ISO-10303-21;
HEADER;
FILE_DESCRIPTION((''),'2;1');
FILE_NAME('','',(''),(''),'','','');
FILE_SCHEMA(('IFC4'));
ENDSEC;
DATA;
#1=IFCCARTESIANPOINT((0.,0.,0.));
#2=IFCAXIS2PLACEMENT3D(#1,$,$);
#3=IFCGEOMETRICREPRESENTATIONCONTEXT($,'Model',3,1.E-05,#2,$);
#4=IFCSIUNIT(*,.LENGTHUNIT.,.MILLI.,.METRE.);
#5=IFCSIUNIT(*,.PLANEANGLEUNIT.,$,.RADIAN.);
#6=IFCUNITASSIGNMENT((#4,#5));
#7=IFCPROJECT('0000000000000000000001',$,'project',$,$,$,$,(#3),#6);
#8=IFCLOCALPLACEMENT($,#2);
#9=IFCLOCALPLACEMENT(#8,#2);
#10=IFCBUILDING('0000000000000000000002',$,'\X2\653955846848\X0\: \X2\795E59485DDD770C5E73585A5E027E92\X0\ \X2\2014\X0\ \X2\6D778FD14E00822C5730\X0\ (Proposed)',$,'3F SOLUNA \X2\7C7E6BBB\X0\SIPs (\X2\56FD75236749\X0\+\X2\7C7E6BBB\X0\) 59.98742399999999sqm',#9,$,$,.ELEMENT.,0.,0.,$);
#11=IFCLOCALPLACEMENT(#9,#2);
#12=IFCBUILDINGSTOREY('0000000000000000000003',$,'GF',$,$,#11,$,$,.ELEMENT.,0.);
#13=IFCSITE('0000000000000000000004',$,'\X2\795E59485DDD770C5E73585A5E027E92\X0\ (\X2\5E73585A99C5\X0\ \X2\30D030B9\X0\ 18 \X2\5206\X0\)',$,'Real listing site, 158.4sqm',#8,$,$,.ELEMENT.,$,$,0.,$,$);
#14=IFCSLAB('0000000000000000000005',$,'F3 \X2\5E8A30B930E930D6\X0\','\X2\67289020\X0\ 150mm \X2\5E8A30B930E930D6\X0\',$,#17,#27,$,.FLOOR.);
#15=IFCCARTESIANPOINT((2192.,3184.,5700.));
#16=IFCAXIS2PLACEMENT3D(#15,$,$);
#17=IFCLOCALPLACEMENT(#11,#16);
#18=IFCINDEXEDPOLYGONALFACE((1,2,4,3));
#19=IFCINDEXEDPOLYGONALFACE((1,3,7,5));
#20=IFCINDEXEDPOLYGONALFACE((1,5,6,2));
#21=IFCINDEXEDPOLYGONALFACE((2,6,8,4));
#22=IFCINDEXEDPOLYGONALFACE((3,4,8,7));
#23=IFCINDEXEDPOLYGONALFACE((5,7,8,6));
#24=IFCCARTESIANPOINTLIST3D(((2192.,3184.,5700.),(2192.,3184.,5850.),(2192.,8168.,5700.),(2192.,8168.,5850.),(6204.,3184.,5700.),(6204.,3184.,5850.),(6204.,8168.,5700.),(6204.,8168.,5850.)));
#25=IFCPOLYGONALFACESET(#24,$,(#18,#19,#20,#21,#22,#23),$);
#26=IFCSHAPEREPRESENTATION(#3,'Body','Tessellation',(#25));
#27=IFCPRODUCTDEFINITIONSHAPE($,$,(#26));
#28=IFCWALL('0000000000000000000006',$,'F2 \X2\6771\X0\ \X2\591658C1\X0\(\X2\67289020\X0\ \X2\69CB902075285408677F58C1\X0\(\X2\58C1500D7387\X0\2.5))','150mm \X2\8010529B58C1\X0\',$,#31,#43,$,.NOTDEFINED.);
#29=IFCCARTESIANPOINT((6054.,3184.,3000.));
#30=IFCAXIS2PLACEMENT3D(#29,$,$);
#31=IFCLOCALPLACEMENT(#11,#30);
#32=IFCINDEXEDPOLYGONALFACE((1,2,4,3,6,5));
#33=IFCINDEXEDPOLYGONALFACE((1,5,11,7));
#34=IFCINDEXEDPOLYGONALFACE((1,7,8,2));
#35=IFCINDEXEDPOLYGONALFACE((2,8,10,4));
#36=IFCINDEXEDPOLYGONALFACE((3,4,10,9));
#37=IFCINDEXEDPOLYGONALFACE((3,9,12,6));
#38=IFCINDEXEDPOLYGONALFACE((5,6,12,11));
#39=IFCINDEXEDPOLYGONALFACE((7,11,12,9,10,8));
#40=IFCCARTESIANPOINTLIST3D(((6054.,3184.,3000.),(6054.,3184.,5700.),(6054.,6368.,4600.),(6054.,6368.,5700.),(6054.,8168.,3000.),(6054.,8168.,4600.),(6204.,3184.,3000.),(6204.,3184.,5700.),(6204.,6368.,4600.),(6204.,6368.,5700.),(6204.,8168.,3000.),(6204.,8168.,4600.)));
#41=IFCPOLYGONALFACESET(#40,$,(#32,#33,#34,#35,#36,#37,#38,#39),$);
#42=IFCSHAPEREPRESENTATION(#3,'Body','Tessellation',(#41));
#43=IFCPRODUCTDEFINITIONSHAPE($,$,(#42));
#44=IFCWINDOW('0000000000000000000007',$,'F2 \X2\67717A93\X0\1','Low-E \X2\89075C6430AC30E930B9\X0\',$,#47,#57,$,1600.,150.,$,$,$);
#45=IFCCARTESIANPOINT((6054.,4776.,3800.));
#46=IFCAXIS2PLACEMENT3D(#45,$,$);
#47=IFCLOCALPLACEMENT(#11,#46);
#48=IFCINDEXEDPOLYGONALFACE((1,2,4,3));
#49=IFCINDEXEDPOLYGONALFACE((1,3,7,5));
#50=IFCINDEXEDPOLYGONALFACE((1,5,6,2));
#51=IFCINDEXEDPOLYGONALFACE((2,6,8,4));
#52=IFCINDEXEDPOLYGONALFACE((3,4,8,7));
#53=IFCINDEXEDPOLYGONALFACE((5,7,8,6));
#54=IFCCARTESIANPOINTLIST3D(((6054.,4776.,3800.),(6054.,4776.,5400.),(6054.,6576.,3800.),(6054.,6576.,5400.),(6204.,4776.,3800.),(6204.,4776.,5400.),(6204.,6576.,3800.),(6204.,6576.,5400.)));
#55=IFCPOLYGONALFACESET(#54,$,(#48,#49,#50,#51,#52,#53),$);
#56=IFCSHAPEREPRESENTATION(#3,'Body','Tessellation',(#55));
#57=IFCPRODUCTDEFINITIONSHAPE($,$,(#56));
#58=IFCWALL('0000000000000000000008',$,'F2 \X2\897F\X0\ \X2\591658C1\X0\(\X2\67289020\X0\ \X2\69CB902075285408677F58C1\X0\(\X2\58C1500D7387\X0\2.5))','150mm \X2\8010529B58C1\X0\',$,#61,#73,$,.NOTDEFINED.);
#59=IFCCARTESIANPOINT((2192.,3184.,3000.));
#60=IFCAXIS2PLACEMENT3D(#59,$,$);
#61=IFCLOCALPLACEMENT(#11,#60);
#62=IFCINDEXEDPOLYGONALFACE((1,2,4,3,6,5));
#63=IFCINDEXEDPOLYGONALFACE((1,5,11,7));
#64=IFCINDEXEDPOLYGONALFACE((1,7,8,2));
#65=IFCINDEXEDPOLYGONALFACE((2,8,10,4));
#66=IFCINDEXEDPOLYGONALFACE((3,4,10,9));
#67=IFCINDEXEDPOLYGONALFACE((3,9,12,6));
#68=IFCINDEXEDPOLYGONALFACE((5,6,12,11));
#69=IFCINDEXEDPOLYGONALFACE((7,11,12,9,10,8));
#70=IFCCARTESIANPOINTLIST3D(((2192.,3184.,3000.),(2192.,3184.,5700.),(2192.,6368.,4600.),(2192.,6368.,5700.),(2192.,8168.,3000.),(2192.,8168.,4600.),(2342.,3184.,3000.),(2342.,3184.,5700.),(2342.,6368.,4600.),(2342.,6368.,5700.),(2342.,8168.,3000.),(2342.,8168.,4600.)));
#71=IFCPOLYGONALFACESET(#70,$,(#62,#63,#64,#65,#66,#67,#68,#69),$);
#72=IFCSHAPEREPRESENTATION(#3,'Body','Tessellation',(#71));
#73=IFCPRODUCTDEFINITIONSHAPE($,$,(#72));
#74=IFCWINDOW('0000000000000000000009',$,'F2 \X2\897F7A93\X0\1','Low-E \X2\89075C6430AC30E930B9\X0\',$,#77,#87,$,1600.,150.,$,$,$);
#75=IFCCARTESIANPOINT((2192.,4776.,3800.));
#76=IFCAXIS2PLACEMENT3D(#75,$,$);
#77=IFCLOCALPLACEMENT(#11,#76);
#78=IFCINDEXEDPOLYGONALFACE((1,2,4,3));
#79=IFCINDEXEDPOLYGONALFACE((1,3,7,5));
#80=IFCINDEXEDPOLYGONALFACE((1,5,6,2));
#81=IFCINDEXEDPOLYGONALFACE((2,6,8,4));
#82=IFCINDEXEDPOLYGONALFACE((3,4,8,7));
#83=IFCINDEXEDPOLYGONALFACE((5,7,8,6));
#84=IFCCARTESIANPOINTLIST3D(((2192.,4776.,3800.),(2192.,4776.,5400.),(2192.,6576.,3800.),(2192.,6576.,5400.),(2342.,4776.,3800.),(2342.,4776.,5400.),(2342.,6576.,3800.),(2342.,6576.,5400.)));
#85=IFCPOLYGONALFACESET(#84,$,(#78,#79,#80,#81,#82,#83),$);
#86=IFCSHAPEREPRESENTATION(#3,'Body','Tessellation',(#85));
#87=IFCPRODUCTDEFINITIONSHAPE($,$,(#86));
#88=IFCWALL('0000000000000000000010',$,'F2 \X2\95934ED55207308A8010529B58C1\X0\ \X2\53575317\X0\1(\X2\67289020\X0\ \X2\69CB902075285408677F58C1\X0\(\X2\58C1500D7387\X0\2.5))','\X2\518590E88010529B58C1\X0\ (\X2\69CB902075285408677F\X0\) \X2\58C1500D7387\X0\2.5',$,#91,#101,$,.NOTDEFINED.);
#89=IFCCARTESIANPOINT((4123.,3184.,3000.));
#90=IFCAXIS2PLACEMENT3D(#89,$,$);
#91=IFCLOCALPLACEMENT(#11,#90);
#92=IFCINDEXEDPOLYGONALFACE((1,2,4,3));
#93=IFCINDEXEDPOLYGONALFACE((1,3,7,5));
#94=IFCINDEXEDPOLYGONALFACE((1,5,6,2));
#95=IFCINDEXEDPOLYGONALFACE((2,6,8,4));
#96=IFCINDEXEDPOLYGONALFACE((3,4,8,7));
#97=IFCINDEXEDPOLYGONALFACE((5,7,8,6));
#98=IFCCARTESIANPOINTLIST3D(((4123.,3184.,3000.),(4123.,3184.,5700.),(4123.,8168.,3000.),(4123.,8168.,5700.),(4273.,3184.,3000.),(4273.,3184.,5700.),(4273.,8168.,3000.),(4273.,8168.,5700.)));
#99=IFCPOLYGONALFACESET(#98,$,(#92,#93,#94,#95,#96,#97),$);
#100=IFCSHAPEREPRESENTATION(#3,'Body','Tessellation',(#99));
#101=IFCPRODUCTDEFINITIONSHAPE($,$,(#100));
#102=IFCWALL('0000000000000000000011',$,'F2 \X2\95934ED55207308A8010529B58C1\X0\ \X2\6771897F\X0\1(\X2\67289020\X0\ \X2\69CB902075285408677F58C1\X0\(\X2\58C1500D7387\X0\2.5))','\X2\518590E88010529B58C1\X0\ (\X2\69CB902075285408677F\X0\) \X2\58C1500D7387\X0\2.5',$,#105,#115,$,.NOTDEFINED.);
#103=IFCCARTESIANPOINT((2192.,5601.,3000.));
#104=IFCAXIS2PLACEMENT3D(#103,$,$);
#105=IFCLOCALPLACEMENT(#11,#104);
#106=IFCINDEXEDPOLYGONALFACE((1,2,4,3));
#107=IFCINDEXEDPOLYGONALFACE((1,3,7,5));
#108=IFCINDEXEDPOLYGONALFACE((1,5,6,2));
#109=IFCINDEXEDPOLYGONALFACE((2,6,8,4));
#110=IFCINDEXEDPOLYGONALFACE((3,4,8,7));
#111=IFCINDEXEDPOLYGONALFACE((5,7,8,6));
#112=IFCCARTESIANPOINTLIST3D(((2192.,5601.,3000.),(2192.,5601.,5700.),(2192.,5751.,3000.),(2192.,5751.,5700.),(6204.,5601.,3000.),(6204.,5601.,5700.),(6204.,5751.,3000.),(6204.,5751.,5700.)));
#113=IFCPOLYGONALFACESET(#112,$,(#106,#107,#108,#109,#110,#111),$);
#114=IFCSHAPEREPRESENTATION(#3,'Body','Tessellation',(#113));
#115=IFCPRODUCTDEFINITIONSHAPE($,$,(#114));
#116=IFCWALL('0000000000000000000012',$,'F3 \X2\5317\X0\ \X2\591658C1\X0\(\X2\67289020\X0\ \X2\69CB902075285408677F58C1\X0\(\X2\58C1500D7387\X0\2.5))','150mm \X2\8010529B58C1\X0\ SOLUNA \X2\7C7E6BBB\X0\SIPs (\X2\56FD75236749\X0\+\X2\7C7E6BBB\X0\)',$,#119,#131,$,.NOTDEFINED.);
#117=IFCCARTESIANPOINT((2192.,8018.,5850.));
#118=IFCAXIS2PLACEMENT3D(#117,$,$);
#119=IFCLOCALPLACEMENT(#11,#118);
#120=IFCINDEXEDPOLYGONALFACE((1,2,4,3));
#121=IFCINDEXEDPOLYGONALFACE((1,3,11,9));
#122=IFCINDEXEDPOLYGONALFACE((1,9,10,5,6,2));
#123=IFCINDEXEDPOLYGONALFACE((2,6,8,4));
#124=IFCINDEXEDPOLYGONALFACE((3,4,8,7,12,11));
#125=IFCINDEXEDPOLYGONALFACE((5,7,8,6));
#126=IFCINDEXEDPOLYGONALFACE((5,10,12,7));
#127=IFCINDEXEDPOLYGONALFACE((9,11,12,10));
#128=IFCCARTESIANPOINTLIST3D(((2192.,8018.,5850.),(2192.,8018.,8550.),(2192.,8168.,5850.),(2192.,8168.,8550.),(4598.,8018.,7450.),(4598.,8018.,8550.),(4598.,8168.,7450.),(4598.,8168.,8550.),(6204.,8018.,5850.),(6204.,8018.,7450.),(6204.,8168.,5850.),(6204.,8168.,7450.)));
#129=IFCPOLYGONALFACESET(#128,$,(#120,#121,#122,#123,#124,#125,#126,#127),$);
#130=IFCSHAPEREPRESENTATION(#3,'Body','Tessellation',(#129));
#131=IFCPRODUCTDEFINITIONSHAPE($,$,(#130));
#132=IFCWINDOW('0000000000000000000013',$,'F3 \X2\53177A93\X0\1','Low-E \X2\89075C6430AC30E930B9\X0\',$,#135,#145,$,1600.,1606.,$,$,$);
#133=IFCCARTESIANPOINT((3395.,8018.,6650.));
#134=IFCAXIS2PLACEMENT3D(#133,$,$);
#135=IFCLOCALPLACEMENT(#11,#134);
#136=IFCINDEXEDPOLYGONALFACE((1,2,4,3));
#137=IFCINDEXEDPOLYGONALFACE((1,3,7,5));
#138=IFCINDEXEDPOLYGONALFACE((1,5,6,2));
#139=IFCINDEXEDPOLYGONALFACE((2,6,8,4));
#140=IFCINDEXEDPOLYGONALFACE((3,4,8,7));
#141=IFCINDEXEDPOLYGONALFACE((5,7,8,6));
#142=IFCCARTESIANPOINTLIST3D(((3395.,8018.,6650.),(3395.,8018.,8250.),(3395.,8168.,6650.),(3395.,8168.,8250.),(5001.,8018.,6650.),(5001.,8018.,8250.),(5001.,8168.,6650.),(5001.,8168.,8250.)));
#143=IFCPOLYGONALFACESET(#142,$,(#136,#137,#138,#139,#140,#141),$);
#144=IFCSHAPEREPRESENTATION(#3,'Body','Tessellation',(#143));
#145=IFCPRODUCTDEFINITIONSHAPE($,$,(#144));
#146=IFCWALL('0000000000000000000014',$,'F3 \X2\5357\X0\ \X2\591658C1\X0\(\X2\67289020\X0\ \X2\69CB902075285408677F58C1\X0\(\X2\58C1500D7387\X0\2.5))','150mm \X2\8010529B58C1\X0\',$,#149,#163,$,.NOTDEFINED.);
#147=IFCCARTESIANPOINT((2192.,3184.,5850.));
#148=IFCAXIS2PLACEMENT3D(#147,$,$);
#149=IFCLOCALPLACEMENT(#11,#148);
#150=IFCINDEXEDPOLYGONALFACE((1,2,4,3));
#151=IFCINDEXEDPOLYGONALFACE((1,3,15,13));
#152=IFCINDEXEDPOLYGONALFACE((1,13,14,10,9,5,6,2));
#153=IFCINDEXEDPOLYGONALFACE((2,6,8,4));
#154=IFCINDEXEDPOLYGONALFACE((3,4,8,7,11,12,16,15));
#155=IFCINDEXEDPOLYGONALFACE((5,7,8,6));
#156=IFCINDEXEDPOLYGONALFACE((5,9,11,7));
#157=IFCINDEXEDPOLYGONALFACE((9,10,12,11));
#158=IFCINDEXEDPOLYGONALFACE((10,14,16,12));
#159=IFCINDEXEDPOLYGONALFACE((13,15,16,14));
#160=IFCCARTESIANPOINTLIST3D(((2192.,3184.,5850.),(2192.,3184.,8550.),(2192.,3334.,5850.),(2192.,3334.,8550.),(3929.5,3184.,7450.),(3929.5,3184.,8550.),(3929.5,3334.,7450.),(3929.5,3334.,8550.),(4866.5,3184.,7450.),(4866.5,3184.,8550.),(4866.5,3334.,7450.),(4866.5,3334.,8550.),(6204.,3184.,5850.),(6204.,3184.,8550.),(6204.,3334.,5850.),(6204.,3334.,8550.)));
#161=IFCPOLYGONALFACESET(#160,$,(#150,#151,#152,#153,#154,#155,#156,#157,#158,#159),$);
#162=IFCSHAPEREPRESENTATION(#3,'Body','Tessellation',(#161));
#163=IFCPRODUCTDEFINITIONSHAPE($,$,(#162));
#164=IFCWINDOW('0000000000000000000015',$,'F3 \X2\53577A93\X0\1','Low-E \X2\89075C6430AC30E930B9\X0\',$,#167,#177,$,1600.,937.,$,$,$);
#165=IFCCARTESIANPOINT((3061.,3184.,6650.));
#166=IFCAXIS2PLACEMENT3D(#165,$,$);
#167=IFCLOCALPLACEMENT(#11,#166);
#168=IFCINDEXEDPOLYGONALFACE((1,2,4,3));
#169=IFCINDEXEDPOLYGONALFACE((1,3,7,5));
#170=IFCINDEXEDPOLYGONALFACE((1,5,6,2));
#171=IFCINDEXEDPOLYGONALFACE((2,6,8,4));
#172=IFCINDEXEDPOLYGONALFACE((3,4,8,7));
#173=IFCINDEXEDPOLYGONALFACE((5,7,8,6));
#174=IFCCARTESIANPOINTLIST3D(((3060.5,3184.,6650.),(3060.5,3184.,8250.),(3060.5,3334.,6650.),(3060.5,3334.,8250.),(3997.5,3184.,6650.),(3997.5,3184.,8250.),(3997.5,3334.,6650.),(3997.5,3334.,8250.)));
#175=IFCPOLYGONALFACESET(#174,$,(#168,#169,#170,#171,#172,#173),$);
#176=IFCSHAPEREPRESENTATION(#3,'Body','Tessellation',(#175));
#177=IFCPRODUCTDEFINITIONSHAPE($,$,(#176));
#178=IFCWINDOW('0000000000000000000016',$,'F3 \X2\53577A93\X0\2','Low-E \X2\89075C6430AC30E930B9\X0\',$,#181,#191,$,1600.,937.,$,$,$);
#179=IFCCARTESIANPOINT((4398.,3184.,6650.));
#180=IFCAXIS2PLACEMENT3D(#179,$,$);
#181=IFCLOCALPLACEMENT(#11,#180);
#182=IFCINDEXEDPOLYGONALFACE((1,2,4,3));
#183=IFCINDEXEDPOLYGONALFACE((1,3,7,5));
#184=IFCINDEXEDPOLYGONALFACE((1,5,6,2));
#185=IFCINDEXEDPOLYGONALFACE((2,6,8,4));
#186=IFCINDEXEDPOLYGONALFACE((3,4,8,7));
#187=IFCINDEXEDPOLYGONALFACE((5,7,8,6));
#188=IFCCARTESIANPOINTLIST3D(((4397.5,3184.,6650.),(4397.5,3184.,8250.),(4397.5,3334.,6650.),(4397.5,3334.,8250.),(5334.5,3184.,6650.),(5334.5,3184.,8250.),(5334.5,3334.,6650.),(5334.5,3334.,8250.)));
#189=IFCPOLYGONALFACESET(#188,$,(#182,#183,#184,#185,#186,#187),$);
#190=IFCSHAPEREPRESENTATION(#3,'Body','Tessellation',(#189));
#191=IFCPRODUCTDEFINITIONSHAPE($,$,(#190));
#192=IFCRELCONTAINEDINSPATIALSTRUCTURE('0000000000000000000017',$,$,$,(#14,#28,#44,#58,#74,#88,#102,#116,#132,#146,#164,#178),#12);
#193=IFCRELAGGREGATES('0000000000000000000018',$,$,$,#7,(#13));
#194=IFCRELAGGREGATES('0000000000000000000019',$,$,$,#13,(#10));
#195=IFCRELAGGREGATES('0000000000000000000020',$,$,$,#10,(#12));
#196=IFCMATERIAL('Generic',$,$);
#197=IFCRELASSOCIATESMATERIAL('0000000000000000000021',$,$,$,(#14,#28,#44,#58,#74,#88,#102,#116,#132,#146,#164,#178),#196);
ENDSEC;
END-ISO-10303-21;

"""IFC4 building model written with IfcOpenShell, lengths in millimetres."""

from ifc_helpers import new_model, si_unit, frame, frame_2d, origin, place, context, project, spatial, rectangle, extrude, material, element, fill, save


model = new_model("IFC4")

# Units and contexts
model_context = context("Model", 3, precision=1e-05, world=origin())
ifc_project = project(units=[si_unit("LENGTHUNIT", "METRE", prefix="MILLI"), si_unit("PLANEANGLEUNIT", "RADIAN")], contexts=[model_context])

# Site, building, storey
site_placement = place(None, origin())
site = spatial("IfcSite", under=ifc_project, at=site_placement, Name="神奈川県平塚市纒 (平塚駅 バス 18 分)", ObjectType="Real listing site, 158.4sqm", CompositionType="ELEMENT", RefElevation=0.0)
building_placement = place(site_placement, origin())
building = spatial("IfcBuilding", under=site, at=building_placement, Name="改善案: 神奈川県平塚市纒 — 海近一般地 (Proposed)", ObjectType="3F SOLUNA 籾殻SIPs (国産杉+籾殻) 59.98742399999999sqm", CompositionType="ELEMENT", ElevationOfRefHeight=0.0, ElevationOfTerrain=0.0)
storey_placement = place(building_placement, origin())
storey = spatial("IfcBuildingStorey", under=building, at=storey_placement, Name="GF", CompositionType="ELEMENT", Elevation=0.0)

# Slab
ifc_material_1 = material(Name="Generic")
slab_placement = place(storey_placement, frame((2192.0, 3184.0, 5700.0)))
element("IfcSlab", 1, at=slab_placement, inside=storey, material=ifc_material_1, Name="F3 床スラブ", Description="木造 150mm 床スラブ", PredefinedType="FLOOR", context=model_context, shape_type="SweptSolid", body=[
    extrude(rectangle(XDim=4012.0, YDim=4984.0, at=frame_2d((2006.0, 2492.0))), frame((2192.0, 3184.0, 5700.0)), (0.0, 0.0, 1.0), 150.0),
])

# Walls, openings, windows
wall_1_placement = place(storey_placement, frame((6054.0, 3184.0, 3000.0)))
wall_1 = element("IfcWall", 2, at=wall_1_placement, inside=storey, material=ifc_material_1, Name="F2 東 外壁(木造 構造用合板壁(壁倍率2.5))", Description="150mm 耐力壁", PredefinedType="NOTDEFINED", context=model_context, shape_type="SweptSolid", body=[
    extrude(rectangle(XDim=150.0, YDim=4984.0, at=frame_2d((75.0, 2492.0))), frame((6054.0, 3184.0, 3000.0)), (0.0, 0.0, 1.0), 2700.0),
])
opening_1_placement = place(storey_placement, frame((6054.0, 4776.0, 3800.0)))
opening_1 = element("IfcOpeningElement", 3, at=opening_1_placement, cuts=wall_1, PredefinedType="NOTDEFINED", context=model_context, shape_type="SweptSolid", body=[
    extrude(rectangle(XDim=150.0, YDim=1800.0, at=frame_2d((75.0, 900.0))), frame((6054.0, 4776.0, 3800.0)), (0.0, 0.0, 1.0), 1600.0),
])
window_1_placement = place(storey_placement, frame((6054.0, 4776.0, 3800.0)))
window_1 = element("IfcWindow", 4, at=window_1_placement, inside=storey, material=ifc_material_1, Name="F2 東窓1", Description="Low-E 複層ガラス", OverallHeight=1600.0, OverallWidth=150.0, context=model_context, shape_type="SweptSolid", body=[
    extrude(rectangle(XDim=150.0, YDim=1800.0, at=frame_2d((75.0, 900.0))), frame((6054.0, 4776.0, 3800.0)), (0.0, 0.0, 1.0), 1600.0),
])
fill(opening_1, window_1)
wall_2_placement = place(storey_placement, frame((2192.0, 3184.0, 3000.0)))
wall_2 = element("IfcWall", 5, at=wall_2_placement, inside=storey, material=ifc_material_1, Name="F2 西 外壁(木造 構造用合板壁(壁倍率2.5))", Description="150mm 耐力壁", PredefinedType="NOTDEFINED", context=model_context, shape_type="SweptSolid", body=[
    extrude(rectangle(XDim=150.0, YDim=4984.0, at=frame_2d((75.0, 2492.0))), frame((2192.0, 3184.0, 3000.0)), (0.0, 0.0, 1.0), 2700.0),
])
opening_2_placement = place(storey_placement, frame((2192.0, 4776.0, 3800.0)))
opening_2 = element("IfcOpeningElement", 6, at=opening_2_placement, cuts=wall_2, PredefinedType="NOTDEFINED", context=model_context, shape_type="SweptSolid", body=[
    extrude(rectangle(XDim=150.0, YDim=1800.0, at=frame_2d((75.0, 900.0))), frame((2192.0, 4776.0, 3800.0)), (0.0, 0.0, 1.0), 1600.0),
])
window_2_placement = place(storey_placement, frame((2192.0, 4776.0, 3800.0)))
window_2 = element("IfcWindow", 7, at=window_2_placement, inside=storey, material=ifc_material_1, Name="F2 西窓1", Description="Low-E 複層ガラス", OverallHeight=1600.0, OverallWidth=150.0, context=model_context, shape_type="SweptSolid", body=[
    extrude(rectangle(XDim=150.0, YDim=1800.0, at=frame_2d((75.0, 900.0))), frame((2192.0, 4776.0, 3800.0)), (0.0, 0.0, 1.0), 1600.0),
])
fill(opening_2, window_2)

# Walls
wall_3_placement = place(storey_placement, frame((4123.0, 3184.0, 3000.0)))
element("IfcWall", 8, at=wall_3_placement, inside=storey, material=ifc_material_1, Name="F2 間仕切り耐力壁 南北1(木造 構造用合板壁(壁倍率2.5))", Description="内部耐力壁 (構造用合板) 壁倍率2.5", PredefinedType="NOTDEFINED", context=model_context, shape_type="SweptSolid", body=[
    extrude(rectangle(XDim=150.0, YDim=4984.0, at=frame_2d((75.0, 2492.0))), frame((4123.0, 3184.0, 3000.0)), (0.0, 0.0, 1.0), 2700.0),
])
wall_4_placement = place(storey_placement, frame((2192.0, 5601.0, 3000.0)))
element("IfcWall", 9, at=wall_4_placement, inside=storey, material=ifc_material_1, Name="F2 間仕切り耐力壁 東西1(木造 構造用合板壁(壁倍率2.5))", Description="内部耐力壁 (構造用合板) 壁倍率2.5", PredefinedType="NOTDEFINED", context=model_context, shape_type="SweptSolid", body=[
    extrude(rectangle(XDim=4012.0, YDim=150.0, at=frame_2d((2006.0, 75.0))), frame((2192.0, 5601.0, 3000.0)), (0.0, 0.0, 1.0), 2700.0),
])

# Wall, opening, window
wall_5_placement = place(storey_placement, frame((2192.0, 8018.0, 5850.0)))
wall_5 = element("IfcWall", 10, at=wall_5_placement, inside=storey, material=ifc_material_1, Name="F3 北 外壁(木造 構造用合板壁(壁倍率2.5))", Description="150mm 耐力壁 SOLUNA 籾殻SIPs (国産杉+籾殻)", PredefinedType="NOTDEFINED", context=model_context, shape_type="SweptSolid", body=[
    extrude(rectangle(XDim=4012.0, YDim=150.0, at=frame_2d((2006.0, 75.0))), frame((2192.0, 8018.0, 5850.0)), (0.0, 0.0, 1.0), 2700.0),
])
opening_3_placement = place(storey_placement, frame((3395.0, 8018.0, 6650.0)))
opening_3 = element("IfcOpeningElement", 11, at=opening_3_placement, cuts=wall_5, PredefinedType="NOTDEFINED", context=model_context, shape_type="SweptSolid", body=[
    extrude(rectangle(XDim=1606.0, YDim=150.0, at=frame_2d((803.0, 75.0))), frame((3395.0, 8018.0, 6650.0)), (0.0, 0.0, 1.0), 1600.0),
])
window_3_placement = place(storey_placement, frame((3395.0, 8018.0, 6650.0)))
window_3 = element("IfcWindow", 12, at=window_3_placement, inside=storey, material=ifc_material_1, Name="F3 北窓1", Description="Low-E 複層ガラス", OverallHeight=1600.0, OverallWidth=1606.0, context=model_context, shape_type="SweptSolid", body=[
    extrude(rectangle(XDim=1606.0, YDim=150.0, at=frame_2d((803.0, 75.0))), frame((3395.0, 8018.0, 6650.0)), (0.0, 0.0, 1.0), 1600.0),
])
fill(opening_3, window_3)

# Wall, openings, windows
wall_6_placement = place(storey_placement, frame((2192.0, 3184.0, 5850.0)))
wall_6 = element("IfcWall", 13, at=wall_6_placement, inside=storey, material=ifc_material_1, Name="F3 南 外壁(木造 構造用合板壁(壁倍率2.5))", Description="150mm 耐力壁", PredefinedType="NOTDEFINED", context=model_context, shape_type="SweptSolid", body=[
    extrude(rectangle(XDim=4012.0, YDim=150.0, at=frame_2d((2006.0, 75.0))), frame((2192.0, 3184.0, 5850.0)), (0.0, 0.0, 1.0), 2700.0),
])
opening_4_placement = place(storey_placement, frame((3061.0, 3184.0, 6650.0)))
opening_4 = element("IfcOpeningElement", 14, at=opening_4_placement, cuts=wall_6, PredefinedType="NOTDEFINED", context=model_context, shape_type="SweptSolid", body=[
    extrude(rectangle(XDim=937.0, YDim=150.0, at=frame_2d((468.0, 75.0))), frame((3061.0, 3184.0, 6650.0)), (0.0, 0.0, 1.0), 1600.0),
])
opening_5_placement = place(storey_placement, frame((4398.0, 3184.0, 6650.0)))
opening_5 = element("IfcOpeningElement", 15, at=opening_5_placement, cuts=wall_6, PredefinedType="NOTDEFINED", context=model_context, shape_type="SweptSolid", body=[
    extrude(rectangle(XDim=937.0, YDim=150.0, at=frame_2d((468.0, 75.0))), frame((4398.0, 3184.0, 6650.0)), (0.0, 0.0, 1.0), 1600.0),
])
window_4_placement = place(storey_placement, frame((3061.0, 3184.0, 6650.0)))
window_4 = element("IfcWindow", 16, at=window_4_placement, inside=storey, material=ifc_material_1, Name="F3 南窓1", Description="Low-E 複層ガラス", OverallHeight=1600.0, OverallWidth=937.0, context=model_context, shape_type="SweptSolid", body=[
    extrude(rectangle(XDim=937.0, YDim=150.0, at=frame_2d((468.0, 75.0))), frame((3061.0, 3184.0, 6650.0)), (0.0, 0.0, 1.0), 1600.0),
])
fill(opening_4, window_4)
window_5_placement = place(storey_placement, frame((4398.0, 3184.0, 6650.0)))
window_5 = element("IfcWindow", 17, at=window_5_placement, inside=storey, material=ifc_material_1, Name="F3 南窓2", Description="Low-E 複層ガラス", OverallHeight=1600.0, OverallWidth=937.0, context=model_context, shape_type="SweptSolid", body=[
    extrude(rectangle(XDim=937.0, YDim=150.0, at=frame_2d((468.0, 75.0))), frame((4398.0, 3184.0, 6650.0)), (0.0, 0.0, 1.0), 1600.0),
])
fill(opening_5, window_5)

save(model, "model.ifc")
